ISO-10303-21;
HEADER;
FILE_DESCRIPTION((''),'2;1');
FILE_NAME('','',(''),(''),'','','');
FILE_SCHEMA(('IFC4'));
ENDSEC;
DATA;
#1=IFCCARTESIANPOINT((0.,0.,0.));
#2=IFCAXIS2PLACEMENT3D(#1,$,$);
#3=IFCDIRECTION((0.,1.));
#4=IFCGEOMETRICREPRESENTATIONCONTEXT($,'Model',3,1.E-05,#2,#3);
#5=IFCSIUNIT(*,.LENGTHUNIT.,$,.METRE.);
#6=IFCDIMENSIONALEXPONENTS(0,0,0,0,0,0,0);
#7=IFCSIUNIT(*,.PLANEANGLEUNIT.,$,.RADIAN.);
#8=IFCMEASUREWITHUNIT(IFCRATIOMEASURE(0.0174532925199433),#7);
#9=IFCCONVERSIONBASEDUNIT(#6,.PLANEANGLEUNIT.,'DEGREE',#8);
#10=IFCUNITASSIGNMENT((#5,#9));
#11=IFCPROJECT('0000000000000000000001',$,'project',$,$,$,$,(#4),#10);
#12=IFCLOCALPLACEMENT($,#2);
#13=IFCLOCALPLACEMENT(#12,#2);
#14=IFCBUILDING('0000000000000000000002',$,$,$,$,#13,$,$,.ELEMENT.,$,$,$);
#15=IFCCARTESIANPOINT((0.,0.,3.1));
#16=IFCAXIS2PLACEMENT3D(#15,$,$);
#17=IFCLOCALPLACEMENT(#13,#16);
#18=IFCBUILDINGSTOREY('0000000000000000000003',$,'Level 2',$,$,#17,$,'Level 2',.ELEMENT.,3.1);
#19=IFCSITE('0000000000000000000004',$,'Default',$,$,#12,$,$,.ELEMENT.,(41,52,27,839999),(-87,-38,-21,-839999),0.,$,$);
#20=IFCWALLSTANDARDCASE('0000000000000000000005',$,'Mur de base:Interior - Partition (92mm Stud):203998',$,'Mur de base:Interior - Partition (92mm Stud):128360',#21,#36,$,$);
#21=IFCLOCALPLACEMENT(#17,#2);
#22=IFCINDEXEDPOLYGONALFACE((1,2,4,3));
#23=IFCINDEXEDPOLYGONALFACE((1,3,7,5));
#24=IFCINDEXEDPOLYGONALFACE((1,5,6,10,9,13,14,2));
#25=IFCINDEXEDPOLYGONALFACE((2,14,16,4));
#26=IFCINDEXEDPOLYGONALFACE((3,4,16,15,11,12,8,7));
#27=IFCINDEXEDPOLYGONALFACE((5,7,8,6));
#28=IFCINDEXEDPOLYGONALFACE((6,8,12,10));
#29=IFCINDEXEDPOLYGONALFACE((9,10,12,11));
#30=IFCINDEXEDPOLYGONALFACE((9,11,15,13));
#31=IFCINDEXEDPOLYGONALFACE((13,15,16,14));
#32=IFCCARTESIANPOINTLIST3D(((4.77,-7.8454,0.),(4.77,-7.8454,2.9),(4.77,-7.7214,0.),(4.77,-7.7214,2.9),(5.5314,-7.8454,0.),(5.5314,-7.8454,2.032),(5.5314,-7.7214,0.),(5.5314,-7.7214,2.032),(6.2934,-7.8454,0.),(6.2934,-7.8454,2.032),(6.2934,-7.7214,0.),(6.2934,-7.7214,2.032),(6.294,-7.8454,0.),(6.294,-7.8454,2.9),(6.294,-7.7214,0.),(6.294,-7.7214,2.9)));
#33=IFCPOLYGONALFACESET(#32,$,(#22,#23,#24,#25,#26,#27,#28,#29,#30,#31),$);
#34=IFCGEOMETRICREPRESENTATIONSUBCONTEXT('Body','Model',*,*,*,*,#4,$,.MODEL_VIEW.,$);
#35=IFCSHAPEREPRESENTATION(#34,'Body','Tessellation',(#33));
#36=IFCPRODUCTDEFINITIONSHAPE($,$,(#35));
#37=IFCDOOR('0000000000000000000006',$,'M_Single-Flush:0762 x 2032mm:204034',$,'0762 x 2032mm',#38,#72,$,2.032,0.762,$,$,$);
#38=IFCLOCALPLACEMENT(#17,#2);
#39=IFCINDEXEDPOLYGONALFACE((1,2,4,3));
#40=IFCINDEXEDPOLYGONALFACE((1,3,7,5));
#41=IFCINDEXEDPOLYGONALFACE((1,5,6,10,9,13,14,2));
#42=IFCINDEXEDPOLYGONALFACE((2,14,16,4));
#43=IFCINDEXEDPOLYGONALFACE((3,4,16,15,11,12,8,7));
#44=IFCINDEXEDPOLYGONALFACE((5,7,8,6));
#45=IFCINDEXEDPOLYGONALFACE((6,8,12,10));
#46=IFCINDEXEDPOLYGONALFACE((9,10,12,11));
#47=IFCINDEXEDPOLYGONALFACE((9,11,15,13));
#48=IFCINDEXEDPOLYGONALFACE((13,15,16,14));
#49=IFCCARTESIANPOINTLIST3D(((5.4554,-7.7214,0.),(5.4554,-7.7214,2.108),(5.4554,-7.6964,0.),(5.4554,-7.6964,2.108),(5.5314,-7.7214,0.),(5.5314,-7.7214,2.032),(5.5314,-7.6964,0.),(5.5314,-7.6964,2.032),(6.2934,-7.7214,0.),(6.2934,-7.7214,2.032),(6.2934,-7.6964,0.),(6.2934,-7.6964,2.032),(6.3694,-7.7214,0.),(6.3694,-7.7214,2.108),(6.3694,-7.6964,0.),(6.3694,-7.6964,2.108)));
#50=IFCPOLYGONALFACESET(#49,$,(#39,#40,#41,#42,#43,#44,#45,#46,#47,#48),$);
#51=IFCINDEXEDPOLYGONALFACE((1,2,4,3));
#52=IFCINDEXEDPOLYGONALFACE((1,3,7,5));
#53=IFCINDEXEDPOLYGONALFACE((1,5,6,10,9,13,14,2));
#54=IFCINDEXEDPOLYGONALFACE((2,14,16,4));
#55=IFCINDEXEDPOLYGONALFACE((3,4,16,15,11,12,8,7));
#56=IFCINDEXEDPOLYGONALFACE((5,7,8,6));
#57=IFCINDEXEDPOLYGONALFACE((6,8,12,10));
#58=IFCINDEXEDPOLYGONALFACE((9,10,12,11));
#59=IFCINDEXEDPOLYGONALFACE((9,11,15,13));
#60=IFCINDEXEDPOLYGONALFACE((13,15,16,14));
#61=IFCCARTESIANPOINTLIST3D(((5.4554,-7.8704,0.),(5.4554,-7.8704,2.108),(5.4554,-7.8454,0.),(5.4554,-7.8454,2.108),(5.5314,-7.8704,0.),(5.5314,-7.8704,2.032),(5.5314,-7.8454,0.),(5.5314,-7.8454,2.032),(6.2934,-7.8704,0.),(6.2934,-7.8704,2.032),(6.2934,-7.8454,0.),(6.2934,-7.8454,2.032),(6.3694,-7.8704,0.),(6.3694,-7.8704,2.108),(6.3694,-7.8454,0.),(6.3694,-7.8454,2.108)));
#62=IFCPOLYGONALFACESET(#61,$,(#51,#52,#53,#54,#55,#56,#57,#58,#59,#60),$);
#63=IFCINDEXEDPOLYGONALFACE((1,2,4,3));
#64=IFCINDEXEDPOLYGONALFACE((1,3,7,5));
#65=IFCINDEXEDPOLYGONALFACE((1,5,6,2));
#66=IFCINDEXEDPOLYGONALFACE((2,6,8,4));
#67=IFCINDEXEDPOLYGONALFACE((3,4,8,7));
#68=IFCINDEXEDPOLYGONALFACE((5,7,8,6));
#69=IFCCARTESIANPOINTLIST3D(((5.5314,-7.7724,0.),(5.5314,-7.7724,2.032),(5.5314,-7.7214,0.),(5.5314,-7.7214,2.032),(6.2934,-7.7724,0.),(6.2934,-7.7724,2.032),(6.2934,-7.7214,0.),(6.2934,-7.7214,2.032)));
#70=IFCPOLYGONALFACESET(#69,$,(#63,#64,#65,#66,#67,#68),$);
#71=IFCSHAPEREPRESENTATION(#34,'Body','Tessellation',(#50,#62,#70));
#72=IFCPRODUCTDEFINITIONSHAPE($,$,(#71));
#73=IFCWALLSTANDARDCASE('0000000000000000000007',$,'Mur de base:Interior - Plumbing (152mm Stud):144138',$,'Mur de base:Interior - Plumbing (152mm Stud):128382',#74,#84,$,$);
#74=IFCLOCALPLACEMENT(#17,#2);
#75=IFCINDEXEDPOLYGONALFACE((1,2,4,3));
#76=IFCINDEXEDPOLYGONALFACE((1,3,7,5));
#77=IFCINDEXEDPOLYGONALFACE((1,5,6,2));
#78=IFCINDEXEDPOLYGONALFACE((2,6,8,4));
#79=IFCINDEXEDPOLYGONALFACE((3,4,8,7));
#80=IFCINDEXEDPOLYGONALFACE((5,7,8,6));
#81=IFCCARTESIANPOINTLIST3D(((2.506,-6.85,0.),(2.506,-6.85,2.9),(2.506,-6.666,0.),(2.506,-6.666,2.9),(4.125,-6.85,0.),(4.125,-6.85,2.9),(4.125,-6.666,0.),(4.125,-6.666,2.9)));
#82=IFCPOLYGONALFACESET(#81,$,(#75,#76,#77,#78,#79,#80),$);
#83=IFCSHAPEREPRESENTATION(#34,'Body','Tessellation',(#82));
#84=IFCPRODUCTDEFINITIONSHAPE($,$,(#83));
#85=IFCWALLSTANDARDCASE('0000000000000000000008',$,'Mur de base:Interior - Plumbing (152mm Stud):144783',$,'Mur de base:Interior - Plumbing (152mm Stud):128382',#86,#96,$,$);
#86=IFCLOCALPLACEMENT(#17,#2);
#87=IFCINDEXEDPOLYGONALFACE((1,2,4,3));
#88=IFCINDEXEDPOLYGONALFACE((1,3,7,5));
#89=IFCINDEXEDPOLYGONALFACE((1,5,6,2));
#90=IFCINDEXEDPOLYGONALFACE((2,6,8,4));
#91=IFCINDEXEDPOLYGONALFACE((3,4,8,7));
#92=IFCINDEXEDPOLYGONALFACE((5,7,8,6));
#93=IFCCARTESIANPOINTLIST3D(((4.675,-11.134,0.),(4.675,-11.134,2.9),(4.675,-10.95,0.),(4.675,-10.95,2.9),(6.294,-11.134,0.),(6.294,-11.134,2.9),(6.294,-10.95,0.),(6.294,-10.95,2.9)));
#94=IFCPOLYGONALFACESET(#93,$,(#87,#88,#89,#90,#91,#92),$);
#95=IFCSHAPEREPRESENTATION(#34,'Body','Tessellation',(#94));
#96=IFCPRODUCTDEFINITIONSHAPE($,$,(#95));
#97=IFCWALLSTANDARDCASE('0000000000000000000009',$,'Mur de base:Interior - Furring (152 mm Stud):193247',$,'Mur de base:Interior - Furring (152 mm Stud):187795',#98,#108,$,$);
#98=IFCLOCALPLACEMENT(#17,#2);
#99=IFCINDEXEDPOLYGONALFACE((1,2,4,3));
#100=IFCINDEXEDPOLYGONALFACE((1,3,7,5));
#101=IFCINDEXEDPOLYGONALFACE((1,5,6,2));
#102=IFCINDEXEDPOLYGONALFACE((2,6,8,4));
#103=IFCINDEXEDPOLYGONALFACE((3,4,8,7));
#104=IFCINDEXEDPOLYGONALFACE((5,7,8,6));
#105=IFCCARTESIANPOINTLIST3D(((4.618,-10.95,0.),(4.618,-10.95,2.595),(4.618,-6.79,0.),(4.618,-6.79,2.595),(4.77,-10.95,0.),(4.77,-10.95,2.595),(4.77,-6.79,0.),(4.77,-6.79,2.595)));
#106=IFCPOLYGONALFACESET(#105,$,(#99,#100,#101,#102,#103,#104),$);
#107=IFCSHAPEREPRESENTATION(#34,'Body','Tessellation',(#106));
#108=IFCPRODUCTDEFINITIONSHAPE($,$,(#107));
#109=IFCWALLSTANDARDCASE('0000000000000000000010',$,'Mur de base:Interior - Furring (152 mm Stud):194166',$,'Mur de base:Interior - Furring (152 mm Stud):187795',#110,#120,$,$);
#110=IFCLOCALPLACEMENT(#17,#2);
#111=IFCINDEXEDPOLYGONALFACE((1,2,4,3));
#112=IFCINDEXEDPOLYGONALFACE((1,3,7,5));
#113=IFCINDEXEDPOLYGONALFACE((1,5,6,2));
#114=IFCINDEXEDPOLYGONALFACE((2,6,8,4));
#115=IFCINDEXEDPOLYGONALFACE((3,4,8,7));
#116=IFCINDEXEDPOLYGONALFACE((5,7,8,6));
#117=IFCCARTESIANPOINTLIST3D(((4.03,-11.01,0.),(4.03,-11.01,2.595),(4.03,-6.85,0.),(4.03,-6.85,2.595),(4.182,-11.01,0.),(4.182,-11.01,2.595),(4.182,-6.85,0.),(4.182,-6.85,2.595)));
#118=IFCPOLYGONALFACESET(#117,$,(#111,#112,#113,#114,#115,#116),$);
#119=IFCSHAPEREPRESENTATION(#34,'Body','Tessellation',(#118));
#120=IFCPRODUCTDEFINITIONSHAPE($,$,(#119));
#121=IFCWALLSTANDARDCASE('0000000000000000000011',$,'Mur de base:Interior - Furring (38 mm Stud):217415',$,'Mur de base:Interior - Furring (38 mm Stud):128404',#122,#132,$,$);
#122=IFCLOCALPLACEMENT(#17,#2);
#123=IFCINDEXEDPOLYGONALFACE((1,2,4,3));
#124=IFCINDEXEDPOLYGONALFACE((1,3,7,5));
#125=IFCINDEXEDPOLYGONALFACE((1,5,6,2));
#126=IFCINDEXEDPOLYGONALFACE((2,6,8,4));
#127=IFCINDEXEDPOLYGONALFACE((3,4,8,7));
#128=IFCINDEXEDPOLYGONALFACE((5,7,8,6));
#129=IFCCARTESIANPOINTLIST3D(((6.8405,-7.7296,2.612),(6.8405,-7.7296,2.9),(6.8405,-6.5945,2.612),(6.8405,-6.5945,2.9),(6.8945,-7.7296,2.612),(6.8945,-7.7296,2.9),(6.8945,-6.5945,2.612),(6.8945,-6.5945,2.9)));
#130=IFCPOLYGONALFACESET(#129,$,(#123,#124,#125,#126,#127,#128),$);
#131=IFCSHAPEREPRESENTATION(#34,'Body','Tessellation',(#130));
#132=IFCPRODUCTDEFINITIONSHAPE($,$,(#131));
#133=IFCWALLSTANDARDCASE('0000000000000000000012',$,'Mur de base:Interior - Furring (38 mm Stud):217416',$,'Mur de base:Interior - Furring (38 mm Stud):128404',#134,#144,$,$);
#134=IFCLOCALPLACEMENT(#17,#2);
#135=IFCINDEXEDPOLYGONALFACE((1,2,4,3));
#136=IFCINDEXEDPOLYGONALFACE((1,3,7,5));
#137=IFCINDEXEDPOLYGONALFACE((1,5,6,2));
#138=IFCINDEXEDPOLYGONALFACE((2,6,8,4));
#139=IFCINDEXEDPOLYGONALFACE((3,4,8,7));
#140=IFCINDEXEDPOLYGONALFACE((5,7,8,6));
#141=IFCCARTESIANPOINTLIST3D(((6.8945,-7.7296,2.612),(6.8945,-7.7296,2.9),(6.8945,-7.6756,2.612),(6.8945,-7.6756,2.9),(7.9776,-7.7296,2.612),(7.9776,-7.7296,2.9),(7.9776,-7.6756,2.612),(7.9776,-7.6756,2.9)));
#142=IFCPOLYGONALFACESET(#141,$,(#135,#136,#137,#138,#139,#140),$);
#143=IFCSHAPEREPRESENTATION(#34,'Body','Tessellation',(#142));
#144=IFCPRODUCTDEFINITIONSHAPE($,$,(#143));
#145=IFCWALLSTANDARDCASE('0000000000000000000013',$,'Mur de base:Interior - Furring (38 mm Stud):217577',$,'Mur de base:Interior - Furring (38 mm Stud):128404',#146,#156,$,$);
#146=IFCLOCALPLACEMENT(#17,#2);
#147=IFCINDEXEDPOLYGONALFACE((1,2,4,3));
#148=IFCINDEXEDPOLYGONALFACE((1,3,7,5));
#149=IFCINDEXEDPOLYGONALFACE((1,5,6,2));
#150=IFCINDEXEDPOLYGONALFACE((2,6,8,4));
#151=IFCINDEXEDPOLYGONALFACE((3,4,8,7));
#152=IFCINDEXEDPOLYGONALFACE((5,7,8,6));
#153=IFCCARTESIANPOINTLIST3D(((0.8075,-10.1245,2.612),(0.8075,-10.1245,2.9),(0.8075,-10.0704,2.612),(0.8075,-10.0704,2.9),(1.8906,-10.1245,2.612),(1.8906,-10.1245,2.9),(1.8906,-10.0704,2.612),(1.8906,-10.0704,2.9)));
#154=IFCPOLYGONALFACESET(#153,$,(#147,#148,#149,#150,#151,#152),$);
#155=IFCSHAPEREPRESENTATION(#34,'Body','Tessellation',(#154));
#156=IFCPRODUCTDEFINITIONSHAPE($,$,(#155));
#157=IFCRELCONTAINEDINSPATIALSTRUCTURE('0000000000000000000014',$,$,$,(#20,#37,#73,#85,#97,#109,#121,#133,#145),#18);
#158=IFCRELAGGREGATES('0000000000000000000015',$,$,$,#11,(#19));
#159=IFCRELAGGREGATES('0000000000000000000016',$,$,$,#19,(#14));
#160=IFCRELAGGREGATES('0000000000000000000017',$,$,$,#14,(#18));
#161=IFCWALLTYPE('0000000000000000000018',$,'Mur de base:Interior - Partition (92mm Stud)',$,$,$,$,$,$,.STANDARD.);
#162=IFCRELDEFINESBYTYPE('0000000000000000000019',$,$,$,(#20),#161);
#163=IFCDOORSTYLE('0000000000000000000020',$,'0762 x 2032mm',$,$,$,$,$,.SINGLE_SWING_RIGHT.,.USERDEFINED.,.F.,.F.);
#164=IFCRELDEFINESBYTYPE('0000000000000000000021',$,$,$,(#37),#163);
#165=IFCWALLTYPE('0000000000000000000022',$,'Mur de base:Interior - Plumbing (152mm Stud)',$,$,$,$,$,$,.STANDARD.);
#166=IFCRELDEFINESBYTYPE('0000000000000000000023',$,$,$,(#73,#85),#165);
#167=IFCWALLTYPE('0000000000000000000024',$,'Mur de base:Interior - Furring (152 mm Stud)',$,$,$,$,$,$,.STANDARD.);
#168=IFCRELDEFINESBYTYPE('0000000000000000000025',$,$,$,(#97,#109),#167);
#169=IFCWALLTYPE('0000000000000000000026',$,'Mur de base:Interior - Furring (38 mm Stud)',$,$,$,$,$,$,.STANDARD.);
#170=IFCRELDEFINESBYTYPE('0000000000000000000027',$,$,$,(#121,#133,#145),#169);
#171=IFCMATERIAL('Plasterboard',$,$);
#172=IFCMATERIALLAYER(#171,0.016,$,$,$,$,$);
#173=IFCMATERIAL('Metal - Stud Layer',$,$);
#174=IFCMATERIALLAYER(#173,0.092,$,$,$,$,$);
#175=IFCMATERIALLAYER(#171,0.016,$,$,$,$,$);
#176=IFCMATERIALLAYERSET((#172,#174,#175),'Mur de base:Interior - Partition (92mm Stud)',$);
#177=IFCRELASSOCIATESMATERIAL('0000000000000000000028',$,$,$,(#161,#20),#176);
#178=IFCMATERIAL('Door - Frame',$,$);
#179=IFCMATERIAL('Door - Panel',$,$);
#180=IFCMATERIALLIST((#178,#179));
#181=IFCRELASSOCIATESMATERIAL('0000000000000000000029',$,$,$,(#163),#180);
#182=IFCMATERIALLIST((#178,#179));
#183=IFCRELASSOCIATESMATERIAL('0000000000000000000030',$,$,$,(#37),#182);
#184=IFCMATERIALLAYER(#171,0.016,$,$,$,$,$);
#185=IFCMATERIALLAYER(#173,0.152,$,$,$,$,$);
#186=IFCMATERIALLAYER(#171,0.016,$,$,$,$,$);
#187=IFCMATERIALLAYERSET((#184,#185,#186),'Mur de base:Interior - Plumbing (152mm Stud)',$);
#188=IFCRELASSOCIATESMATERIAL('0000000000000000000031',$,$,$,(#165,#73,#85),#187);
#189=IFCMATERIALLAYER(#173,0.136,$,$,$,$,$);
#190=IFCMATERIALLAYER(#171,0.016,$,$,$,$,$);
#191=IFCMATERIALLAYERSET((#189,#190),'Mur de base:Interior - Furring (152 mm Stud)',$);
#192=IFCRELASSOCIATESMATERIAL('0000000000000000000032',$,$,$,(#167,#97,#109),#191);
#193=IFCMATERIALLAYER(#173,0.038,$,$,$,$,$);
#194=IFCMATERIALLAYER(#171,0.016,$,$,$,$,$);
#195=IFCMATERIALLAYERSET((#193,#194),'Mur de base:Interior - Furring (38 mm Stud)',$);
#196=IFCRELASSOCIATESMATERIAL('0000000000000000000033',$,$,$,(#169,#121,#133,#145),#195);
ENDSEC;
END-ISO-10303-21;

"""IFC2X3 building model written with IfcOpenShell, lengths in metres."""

from ifc_helpers import new_model, entity, si_unit, converted_unit, direction, frame, frame_2d, origin, origin_2d_with_axis, place, context, subcontext, project, spatial, polyline, rectangle, outline, extrude, source, transform, mapped, material, material_list, layer, layer_set, layer_usage, type_object, type_shapes, element, fill, save


model = new_model("IFC2X3")

# Units and contexts
model_context = context("Model", 3, precision=1e-05, world=origin(), true_north=direction((0.0, 1.0)))
body_context = subcontext(model_context, "Body", "Model", "MODEL_VIEW")
ifc_project = project(units=[si_unit("LENGTHUNIT", "METRE"), converted_unit("PLANEANGLEUNIT", "DEGREE", entity("IfcRatioMeasure", 0.0174532925199433), si_unit("PLANEANGLEUNIT", "RADIAN"), dimensions=[0, 0, 0, 0, 0, 0, 0])], contexts=[model_context])

# Site, building, storey
site_placement = place(None, origin())
site = spatial("IfcSite", under=ifc_project, at=site_placement, Name="Default", CompositionType="ELEMENT", RefLatitude=(41, 52, 27, 839999), RefLongitude=(-87, -38, -21, -839999), RefElevation=0.0)
building_placement = place(site_placement, origin())
building = spatial("IfcBuilding", under=site, at=building_placement, CompositionType="ELEMENT")
storey_placement = place(building_placement, frame((0.0, 0.0, 3.1)))
storey = spatial("IfcBuildingStorey", under=building, at=storey_placement, Name="Level 2", LongName="Level 2", CompositionType="ELEMENT", Elevation=3.1)

# Shared definitions
ifc_material_1 = material(Name="Plasterboard")
ifc_layer_1 = layer(ifc_material_1, 0.016)
ifc_material_2 = material(Name="Metal - Stud Layer")
ifc_layer_2 = layer(ifc_material_2, 0.092)
ifc_layer_3 = layer(ifc_material_1, 0.016)
ifc_layer_set_1 = layer_set([ifc_layer_1, ifc_layer_2, ifc_layer_3], Name="Mur de base:Interior - Partition (92mm Stud)")
wall_type_1 = type_object("IfcWallType", Name="Mur de base:Interior - Partition (92mm Stud)", PredefinedType="STANDARD", material=ifc_layer_set_1)

# Wall, opening, door
ifc_material_3 = material(Name="Door - Frame")
ifc_material_4 = material(Name="Door - Panel")
ifc_material_list_1 = material_list([ifc_material_3, ifc_material_4])
door_style = type_object("IfcDoorStyle", Name="0762 x 2032mm", ConstructionType="USERDEFINED", OperationType="SINGLE_SWING_RIGHT", ParameterTakesPrecedence=False, Sizeable=False, material=ifc_material_list_1)
shared_shape_1 = source(origin(), body_context, "Body", "SweptSolid", [
    extrude(outline(polyline([(-0.457, -1.073), (0.457, -1.073), (0.457, 1.035), (0.381, 1.035), (0.381, -0.997), (-0.381, -0.997), (-0.381, 1.035), (-0.457, 1.035), (-0.457, -1.073)])), frame((0.381, 0.124, 1.035), z_axis=(0.0, 1.0, 0.0), x_axis=(1.0, 0.0, 0.0)), (0.0, 0.0, 1.0), 0.025),
    extrude(outline(polyline([(-1.073, -0.457), (1.035, -0.457), (1.035, -0.381), (-0.997, -0.381), (-0.997, 0.381), (1.035, 0.381), (1.035, 0.457), (-1.073, 0.457), (-1.073, -0.457)])), frame((0.381, -0.025, 1.035), z_axis=(0.0, 1.0, 0.0), x_axis=(0.0, 0.0, -1.0)), (0.0, 0.0, 1.0), 0.025),
    extrude(rectangle(XDim=0.051, YDim=0.762, at=origin_2d_with_axis()), frame((0.381, 0.0985, 0.0), z_axis=(0.0, 0.0, 1.0), x_axis=(0.0, 1.0, 0.0)), (0.0, 0.0, 1.0), 2.032),
])
type_shapes(door_style, [shared_shape_1])
ifc_layer_usage_1 = layer_usage(ifc_layer_set_1, "AXIS2", "POSITIVE", -0.062)
wall_1_placement = place(storey_placement, frame((4.77, -7.7834, 0.0)))
wall_1 = element("IfcWallStandardCase", 1, at=wall_1_placement, inside=storey, type_object=wall_type_1, material=ifc_layer_usage_1, Name="Mur de base:Interior - Partition (92mm Stud):203998", ObjectType="Mur de base:Interior - Partition (92mm Stud):128360", context=body_context, shape_type="SweptSolid", body=[
    extrude(rectangle(XDim=1.524, YDim=0.124, at=frame_2d((0.762, 0.0), x_axis=(-1.0, 0.0))), origin(), (0.0, 0.0, 1.0), 2.9),
])
opening_1_placement = place(wall_1_placement, frame((0.7614, -0.062, 0.0)))
opening_1 = element("IfcOpeningElement", 2, at=opening_1_placement, cuts=wall_1, ObjectType="Opening", context=body_context, shape_type="SweptSolid", body=[
    extrude(rectangle(XDim=0.762, YDim=2.032, at=frame_2d((1.016, 0.381), x_axis=(0.0, 1.0))), frame((0.0, 0.0, 0.0), z_axis=(0.0, 1.0, 0.0), x_axis=(0.0, 0.0, 1.0)), (0.0, 0.0, 1.0), 0.124),
])
ifc_material_list_2 = material_list([ifc_material_3, ifc_material_4])
door_1_placement = place(opening_1_placement, origin())
door_1 = element("IfcDoor", 3, at=door_1_placement, inside=storey, type_object=door_style, material=ifc_material_list_2, Name="M_Single-Flush:0762 x 2032mm:204034", ObjectType="0762 x 2032mm", OverallHeight=2.032, OverallWidth=0.762, context=body_context, shape_type="MappedRepresentation", body=[
    mapped(shared_shape_1, transform((0.0, 0.0, 0.0), scale=1.0)),
])
fill(opening_1, door_1)

# Walls
ifc_layer_4 = layer(ifc_material_1, 0.016)
ifc_layer_5 = layer(ifc_material_2, 0.152)
ifc_layer_6 = layer(ifc_material_1, 0.016)
ifc_layer_set_2 = layer_set([ifc_layer_4, ifc_layer_5, ifc_layer_6], Name="Mur de base:Interior - Plumbing (152mm Stud)")
ifc_layer_usage_2 = layer_usage(ifc_layer_set_2, "AXIS2", "NEGATIVE", 0.092)
wall_type_2 = type_object("IfcWallType", Name="Mur de base:Interior - Plumbing (152mm Stud)", PredefinedType="STANDARD", material=ifc_layer_set_2)
wall_2_placement = place(storey_placement, frame((2.506, -6.758, 0.0)))
element("IfcWallStandardCase", 4, at=wall_2_placement, inside=storey, type_object=wall_type_2, material=ifc_layer_usage_2, Name="Mur de base:Interior - Plumbing (152mm Stud):144138", ObjectType="Mur de base:Interior - Plumbing (152mm Stud):128382", context=body_context, shape_type="SweptSolid", body=[
    extrude(rectangle(XDim=1.619, YDim=0.184, at=frame_2d((0.8095, 0.0), x_axis=(-1.0, 0.0))), origin(), (0.0, 0.0, 1.0), 2.9),
])
ifc_layer_usage_3 = layer_usage(ifc_layer_set_2, "AXIS2", "NEGATIVE", 0.092)
wall_3_placement = place(storey_placement, frame((6.294, -11.042, 0.0), z_axis=(0.0, 0.0, 1.0), x_axis=(-1.0, 0.0, 0.0)))
element("IfcWallStandardCase", 5, at=wall_3_placement, inside=storey, type_object=wall_type_2, material=ifc_layer_usage_3, Name="Mur de base:Interior - Plumbing (152mm Stud):144783", ObjectType="Mur de base:Interior - Plumbing (152mm Stud):128382", context=body_context, shape_type="SweptSolid", body=[
    extrude(rectangle(XDim=1.619, YDim=0.184, at=frame_2d((0.8095, 0.0), x_axis=(-1.0, 0.0))), origin(), (0.0, 0.0, 1.0), 2.9),
])
ifc_layer_7 = layer(ifc_material_2, 0.136)
ifc_layer_8 = layer(ifc_material_1, 0.016)
ifc_layer_set_3 = layer_set([ifc_layer_7, ifc_layer_8], Name="Mur de base:Interior - Furring (152 mm Stud)")
ifc_layer_usage_4 = layer_usage(ifc_layer_set_3, "AXIS2", "POSITIVE", -0.076)
wall_type_3 = type_object("IfcWallType", Name="Mur de base:Interior - Furring (152 mm Stud)", PredefinedType="STANDARD", material=ifc_layer_set_3)
wall_4_placement = place(storey_placement, frame((4.694, -6.79, 0.0), z_axis=(0.0, 0.0, 1.0), x_axis=(0.0, -1.0, 0.0)))
element("IfcWallStandardCase", 6, at=wall_4_placement, inside=storey, type_object=wall_type_3, material=ifc_layer_usage_4, Name="Mur de base:Interior - Furring (152 mm Stud):193247", ObjectType="Mur de base:Interior - Furring (152 mm Stud):187795", context=body_context, shape_type="SweptSolid", body=[
    extrude(rectangle(XDim=4.16, YDim=0.152, at=frame_2d((2.08, 0.0), x_axis=(-1.0, 0.0))), origin(), (0.0, 0.0, 1.0), 2.595),
])
ifc_layer_usage_5 = layer_usage(ifc_layer_set_3, "AXIS2", "POSITIVE", -0.076)
wall_5_placement = place(storey_placement, frame((4.106, -11.01, 0.0), z_axis=(0.0, 0.0, 1.0), x_axis=(0.0, 1.0, 0.0)))
element("IfcWallStandardCase", 7, at=wall_5_placement, inside=storey, type_object=wall_type_3, material=ifc_layer_usage_5, Name="Mur de base:Interior - Furring (152 mm Stud):194166", ObjectType="Mur de base:Interior - Furring (152 mm Stud):187795", context=body_context, shape_type="SweptSolid", body=[
    extrude(rectangle(XDim=4.16, YDim=0.152, at=frame_2d((2.08, 0.0), x_axis=(-1.0, 0.0))), origin(), (0.0, 0.0, 1.0), 2.595),
])
ifc_layer_9 = layer(ifc_material_2, 0.038)
ifc_layer_10 = layer(ifc_material_1, 0.016)
ifc_layer_set_4 = layer_set([ifc_layer_9, ifc_layer_10], Name="Mur de base:Interior - Furring (38 mm Stud)")
ifc_layer_usage_6 = layer_usage(ifc_layer_set_4, "AXIS2", "NEGATIVE", 0.027)
wall_type_4 = type_object("IfcWallType", Name="Mur de base:Interior - Furring (38 mm Stud)", PredefinedType="STANDARD", material=ifc_layer_set_4)
wall_6_placement = place(storey_placement, frame((6.8675, -7.7296, 2.612), z_axis=(0.0, 0.0, 1.0), x_axis=(0.0, 1.0, 0.0)))
element("IfcWallStandardCase", 8, at=wall_6_placement, inside=storey, type_object=wall_type_4, material=ifc_layer_usage_6, Name="Mur de base:Interior - Furring (38 mm Stud):217415", ObjectType="Mur de base:Interior - Furring (38 mm Stud):128404", context=body_context, shape_type="SweptSolid", body=[
    extrude(rectangle(XDim=1.1351, YDim=0.054, at=frame_2d((0.5675, 0.0), x_axis=(-1.0, 0.0))), origin(), (0.0, 0.0, 1.0), 0.288),
])
ifc_layer_usage_7 = layer_usage(ifc_layer_set_4, "AXIS2", "NEGATIVE", 0.027)
wall_7_placement = place(storey_placement, frame((7.9776, -7.7026, 2.612), z_axis=(0.0, 0.0, 1.0), x_axis=(-1.0, 0.0, 0.0)))
element("IfcWallStandardCase", 9, at=wall_7_placement, inside=storey, type_object=wall_type_4, material=ifc_layer_usage_7, Name="Mur de base:Interior - Furring (38 mm Stud):217416", ObjectType="Mur de base:Interior - Furring (38 mm Stud):128404", context=body_context, shape_type="SweptSolid", body=[
    extrude(rectangle(XDim=1.0831, YDim=0.054, at=frame_2d((0.5415, 0.0), x_axis=(-1.0, 0.0))), origin(), (0.0, 0.0, 1.0), 0.288),
])
ifc_layer_usage_8 = layer_usage(ifc_layer_set_4, "AXIS2", "NEGATIVE", 0.027)
wall_8_placement = place(storey_placement, frame((0.8075, -10.0975, 2.612)))
element("IfcWallStandardCase", 10, at=wall_8_placement, inside=storey, type_object=wall_type_4, material=ifc_layer_usage_8, Name="Mur de base:Interior - Furring (38 mm Stud):217577", ObjectType="Mur de base:Interior - Furring (38 mm Stud):128404", context=body_context, shape_type="SweptSolid", body=[
    extrude(rectangle(XDim=1.0831, YDim=0.054, at=frame_2d((0.5415, 0.0), x_axis=(-1.0, 0.0))), origin(), (0.0, 0.0, 1.0), 0.288),
])

save(model, "model.ifc")
